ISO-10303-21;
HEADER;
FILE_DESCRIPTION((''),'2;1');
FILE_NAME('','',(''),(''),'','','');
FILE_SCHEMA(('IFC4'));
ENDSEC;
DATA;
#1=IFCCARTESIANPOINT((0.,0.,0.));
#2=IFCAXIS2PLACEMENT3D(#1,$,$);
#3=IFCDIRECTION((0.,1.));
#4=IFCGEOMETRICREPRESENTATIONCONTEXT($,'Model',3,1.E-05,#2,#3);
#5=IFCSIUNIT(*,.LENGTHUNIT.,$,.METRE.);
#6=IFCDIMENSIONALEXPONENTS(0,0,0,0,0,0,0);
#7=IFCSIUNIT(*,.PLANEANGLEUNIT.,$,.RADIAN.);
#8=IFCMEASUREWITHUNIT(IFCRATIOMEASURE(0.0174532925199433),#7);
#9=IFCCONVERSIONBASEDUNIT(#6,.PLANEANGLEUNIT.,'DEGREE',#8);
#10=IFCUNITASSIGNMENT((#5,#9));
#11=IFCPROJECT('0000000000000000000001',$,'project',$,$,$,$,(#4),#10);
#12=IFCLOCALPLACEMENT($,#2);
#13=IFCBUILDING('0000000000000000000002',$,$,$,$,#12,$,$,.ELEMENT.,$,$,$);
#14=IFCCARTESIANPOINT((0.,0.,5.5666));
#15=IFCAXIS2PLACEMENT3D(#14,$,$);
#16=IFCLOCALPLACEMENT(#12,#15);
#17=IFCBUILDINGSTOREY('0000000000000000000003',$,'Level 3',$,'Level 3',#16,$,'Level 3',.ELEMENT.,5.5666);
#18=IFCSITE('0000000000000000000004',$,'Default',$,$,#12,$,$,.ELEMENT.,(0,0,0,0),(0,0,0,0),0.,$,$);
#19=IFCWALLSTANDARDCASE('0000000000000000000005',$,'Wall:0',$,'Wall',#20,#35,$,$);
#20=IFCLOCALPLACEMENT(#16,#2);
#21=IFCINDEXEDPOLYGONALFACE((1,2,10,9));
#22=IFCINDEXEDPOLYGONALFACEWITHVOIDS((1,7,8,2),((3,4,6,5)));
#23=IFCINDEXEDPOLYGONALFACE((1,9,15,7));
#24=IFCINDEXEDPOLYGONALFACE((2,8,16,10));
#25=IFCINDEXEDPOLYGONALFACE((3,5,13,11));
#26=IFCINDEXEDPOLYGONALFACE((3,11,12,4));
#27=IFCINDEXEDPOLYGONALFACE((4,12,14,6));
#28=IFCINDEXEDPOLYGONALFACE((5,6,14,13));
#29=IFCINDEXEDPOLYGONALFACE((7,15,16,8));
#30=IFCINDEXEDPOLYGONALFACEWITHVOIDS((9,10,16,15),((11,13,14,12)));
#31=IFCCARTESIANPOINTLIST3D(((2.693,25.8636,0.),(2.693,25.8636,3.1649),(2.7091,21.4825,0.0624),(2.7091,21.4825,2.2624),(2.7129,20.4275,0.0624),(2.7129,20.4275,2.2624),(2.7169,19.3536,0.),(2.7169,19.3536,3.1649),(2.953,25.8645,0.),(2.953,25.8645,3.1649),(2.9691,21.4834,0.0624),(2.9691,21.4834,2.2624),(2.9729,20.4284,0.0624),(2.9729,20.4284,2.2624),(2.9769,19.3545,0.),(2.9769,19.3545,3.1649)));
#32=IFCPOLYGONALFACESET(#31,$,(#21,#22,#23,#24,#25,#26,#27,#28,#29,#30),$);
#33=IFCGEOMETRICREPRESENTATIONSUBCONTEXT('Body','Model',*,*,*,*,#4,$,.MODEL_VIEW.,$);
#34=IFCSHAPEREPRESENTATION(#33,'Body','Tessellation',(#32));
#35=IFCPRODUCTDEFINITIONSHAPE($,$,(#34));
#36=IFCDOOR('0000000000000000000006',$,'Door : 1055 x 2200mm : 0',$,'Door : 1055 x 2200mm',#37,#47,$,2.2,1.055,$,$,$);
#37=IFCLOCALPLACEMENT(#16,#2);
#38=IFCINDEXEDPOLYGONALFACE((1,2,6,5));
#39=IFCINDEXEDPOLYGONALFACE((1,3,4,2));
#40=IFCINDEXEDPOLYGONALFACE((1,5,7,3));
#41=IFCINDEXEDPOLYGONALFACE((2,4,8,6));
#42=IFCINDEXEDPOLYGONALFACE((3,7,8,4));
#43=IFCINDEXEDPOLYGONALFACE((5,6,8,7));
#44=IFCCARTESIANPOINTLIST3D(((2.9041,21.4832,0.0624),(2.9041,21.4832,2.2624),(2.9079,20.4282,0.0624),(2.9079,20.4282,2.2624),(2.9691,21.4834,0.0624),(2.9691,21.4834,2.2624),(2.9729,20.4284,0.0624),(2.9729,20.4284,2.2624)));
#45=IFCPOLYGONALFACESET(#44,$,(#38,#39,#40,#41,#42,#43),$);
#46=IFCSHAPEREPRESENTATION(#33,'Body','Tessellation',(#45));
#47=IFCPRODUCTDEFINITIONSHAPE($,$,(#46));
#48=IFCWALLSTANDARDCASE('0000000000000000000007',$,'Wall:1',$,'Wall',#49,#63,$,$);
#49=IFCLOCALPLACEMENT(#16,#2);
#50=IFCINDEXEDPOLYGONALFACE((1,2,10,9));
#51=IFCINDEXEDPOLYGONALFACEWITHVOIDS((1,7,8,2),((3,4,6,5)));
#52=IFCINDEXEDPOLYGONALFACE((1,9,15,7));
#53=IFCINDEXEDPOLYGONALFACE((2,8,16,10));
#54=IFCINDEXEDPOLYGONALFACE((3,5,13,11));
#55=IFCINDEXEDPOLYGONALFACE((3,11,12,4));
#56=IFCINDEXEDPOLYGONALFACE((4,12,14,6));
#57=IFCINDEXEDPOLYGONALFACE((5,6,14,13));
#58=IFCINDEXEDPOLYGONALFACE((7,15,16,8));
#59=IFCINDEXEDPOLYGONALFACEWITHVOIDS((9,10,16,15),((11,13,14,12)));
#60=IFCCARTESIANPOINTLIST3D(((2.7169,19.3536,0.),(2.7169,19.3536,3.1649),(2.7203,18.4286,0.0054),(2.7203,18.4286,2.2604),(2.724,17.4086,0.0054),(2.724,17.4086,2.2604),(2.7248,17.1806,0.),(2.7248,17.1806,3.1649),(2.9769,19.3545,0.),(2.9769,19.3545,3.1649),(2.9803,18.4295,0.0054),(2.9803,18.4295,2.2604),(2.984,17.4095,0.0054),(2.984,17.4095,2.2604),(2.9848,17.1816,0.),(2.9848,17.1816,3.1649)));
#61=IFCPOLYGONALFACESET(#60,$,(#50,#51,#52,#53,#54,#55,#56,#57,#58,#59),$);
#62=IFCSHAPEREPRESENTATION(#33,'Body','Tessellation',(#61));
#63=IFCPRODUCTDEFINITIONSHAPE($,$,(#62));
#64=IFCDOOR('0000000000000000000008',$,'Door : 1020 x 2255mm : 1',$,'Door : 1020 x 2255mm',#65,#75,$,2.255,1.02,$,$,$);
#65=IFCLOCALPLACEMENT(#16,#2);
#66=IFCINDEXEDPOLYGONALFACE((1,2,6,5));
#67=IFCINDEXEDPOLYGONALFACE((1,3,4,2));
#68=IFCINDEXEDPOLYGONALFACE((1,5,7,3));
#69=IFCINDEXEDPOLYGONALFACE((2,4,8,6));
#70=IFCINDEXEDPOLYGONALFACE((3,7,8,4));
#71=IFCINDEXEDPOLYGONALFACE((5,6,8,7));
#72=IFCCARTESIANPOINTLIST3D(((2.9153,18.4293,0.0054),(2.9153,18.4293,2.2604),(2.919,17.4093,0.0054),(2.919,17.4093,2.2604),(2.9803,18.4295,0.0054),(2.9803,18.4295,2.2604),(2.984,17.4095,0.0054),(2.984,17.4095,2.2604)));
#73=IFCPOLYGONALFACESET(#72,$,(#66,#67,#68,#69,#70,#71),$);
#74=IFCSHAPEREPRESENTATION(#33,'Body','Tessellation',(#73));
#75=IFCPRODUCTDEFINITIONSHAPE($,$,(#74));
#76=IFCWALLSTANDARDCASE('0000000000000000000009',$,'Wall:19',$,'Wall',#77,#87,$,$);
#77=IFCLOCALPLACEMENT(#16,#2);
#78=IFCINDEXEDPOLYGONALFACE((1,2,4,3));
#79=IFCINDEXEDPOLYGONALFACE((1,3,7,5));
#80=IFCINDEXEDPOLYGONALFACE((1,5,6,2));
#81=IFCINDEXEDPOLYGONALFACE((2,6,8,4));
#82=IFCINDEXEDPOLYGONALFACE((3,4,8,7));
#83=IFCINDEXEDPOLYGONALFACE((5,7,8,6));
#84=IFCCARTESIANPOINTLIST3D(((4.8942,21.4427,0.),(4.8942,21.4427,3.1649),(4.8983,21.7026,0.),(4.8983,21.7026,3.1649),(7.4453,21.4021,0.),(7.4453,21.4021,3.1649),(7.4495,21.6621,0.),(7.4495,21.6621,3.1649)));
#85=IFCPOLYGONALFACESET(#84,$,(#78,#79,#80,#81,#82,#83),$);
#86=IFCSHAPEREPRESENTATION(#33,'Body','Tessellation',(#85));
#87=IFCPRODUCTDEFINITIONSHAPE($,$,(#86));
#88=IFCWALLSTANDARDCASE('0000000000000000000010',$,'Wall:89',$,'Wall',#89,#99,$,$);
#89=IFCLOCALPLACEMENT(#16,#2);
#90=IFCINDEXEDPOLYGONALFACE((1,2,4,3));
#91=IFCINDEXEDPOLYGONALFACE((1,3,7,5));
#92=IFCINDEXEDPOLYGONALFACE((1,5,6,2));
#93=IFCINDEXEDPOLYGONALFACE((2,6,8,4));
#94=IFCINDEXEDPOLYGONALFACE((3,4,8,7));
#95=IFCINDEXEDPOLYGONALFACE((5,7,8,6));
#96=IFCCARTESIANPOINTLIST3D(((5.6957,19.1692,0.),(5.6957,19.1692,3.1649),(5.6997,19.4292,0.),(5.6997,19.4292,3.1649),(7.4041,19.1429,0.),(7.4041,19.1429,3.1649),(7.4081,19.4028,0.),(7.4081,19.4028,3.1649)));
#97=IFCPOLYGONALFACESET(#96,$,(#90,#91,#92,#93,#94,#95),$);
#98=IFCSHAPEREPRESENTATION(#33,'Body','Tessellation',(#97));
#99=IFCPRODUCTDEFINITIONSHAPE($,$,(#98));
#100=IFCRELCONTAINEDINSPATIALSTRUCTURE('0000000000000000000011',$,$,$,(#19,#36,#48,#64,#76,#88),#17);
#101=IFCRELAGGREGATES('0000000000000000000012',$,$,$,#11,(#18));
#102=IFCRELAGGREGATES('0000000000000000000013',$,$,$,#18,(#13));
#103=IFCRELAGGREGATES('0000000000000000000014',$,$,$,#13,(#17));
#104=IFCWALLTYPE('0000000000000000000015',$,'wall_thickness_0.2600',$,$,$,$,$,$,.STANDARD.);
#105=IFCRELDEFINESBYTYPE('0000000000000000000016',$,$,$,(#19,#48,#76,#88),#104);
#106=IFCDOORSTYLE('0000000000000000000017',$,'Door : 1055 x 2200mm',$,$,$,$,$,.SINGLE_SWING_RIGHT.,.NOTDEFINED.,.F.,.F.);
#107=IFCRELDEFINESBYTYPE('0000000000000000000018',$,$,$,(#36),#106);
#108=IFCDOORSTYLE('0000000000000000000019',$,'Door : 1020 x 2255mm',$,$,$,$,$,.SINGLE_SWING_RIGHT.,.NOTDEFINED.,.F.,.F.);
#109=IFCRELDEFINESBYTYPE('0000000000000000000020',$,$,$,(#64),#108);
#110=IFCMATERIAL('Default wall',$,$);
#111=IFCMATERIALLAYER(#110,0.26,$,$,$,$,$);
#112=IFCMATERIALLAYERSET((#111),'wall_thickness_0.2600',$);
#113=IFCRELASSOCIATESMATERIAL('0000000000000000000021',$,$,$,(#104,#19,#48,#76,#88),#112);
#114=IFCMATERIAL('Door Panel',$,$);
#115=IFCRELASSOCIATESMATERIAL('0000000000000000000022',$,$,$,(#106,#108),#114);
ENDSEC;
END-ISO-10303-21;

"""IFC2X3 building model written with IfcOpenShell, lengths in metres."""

from ifc_helpers import new_model, entity, si_unit, converted_unit, direction, frame, frame_2d, origin, origin_2d_with_axis, place, context, subcontext, project, spatial, polyline, rectangle, outline, extrude, source, transform, mapped, material, layer, layer_set, layer_usage, type_object, type_shapes, element, fill, save


model = new_model("IFC2X3")

# Units and contexts
model_context = context("Model", 3, precision=1e-05, world=origin(), true_north=direction((0.0, 1.0)))
body_context = subcontext(model_context, "Body", "Model", "MODEL_VIEW")
ifc_project = project(units=[si_unit("LENGTHUNIT", "METRE"), converted_unit("PLANEANGLEUNIT", "DEGREE", entity("IfcRatioMeasure", 0.0174532925199433), si_unit("PLANEANGLEUNIT", "RADIAN"), dimensions=[0, 0, 0, 0, 0, 0, 0])], contexts=[model_context])

# Site, building, storey
placement_1 = place(None, origin())
site = spatial("IfcSite", under=ifc_project, at=placement_1, Name="Default", CompositionType="ELEMENT", RefLatitude=(0, 0, 0, 0), RefLongitude=(0, 0, 0, 0), RefElevation=0.0)
building = spatial("IfcBuilding", under=site, at=placement_1, CompositionType="ELEMENT")
storey_placement = place(placement_1, frame((0.0, 0.0, 5.5666)))
storey = spatial("IfcBuildingStorey", under=building, at=storey_placement, Name="Level 3", ObjectType="Level 3", LongName="Level 3", CompositionType="ELEMENT", Elevation=5.5666)

# Walls, openings, doors
ifc_material_1 = material(Name="Default wall")
ifc_layer_1 = layer(ifc_material_1, 0.26)
ifc_layer_set_1 = layer_set([ifc_layer_1], Name="wall_thickness_0.2600")
ifc_layer_usage_1 = layer_usage(ifc_layer_set_1, "AXIS2", "POSITIVE", -0.13)
wall_type_1 = type_object("IfcWallType", Name="wall_thickness_0.2600", PredefinedType="STANDARD", material=ifc_layer_set_1)
wall_1_placement = place(storey_placement, frame((2.823, 25.8641, 0.0), z_axis=(0.0, 0.0, 1.0), x_axis=(0.003663, -0.999993, 0.0)))
wall_1 = element("IfcWallStandardCase", 1, at=wall_1_placement, inside=storey, type_object=wall_type_1, material=ifc_layer_usage_1, Name="Wall:0", ObjectType="Wall", context=body_context, shape_type="SweptSolid", body=[
    extrude(outline(polyline([(6.5101, -0.13), (6.5101, 0.13), (0.0, 0.13), (0.0, -0.13), (6.5101, -0.13)])), origin(), (0.0, 0.0, 1.0), 3.1649),
])
opening_1_placement = place(wall_1_placement, frame((4.3811, -0.13, 0.0624)))
opening_1 = element("IfcOpeningElement", 2, at=opening_1_placement, cuts=wall_1, ObjectType="Opening", context=body_context, shape_type="SweptSolid", body=[
    extrude(rectangle(XDim=1.055, YDim=2.2, at=frame_2d((1.1, 0.5275), x_axis=(0.0, 1.0))), frame((0.0, 0.0, 0.0), z_axis=(0.0, 1.0, 0.0), x_axis=(0.0, 0.0, 1.0)), (0.0, 0.0, 1.0), 0.26),
])
ifc_material_2 = material(Name="Door Panel")
door_style_1 = type_object("IfcDoorStyle", Name="Door : 1055 x 2200mm", ConstructionType="NOTDEFINED", OperationType="SINGLE_SWING_RIGHT", ParameterTakesPrecedence=False, Sizeable=False, material=ifc_material_2)
shared_shape_1 = source(origin(), body_context, "Body", "SweptSolid", [
    extrude(rectangle(XDim=0.065, YDim=1.055, at=origin_2d_with_axis()), frame((0.5275, 0.2275, 0.0), z_axis=(0.0, 0.0, 1.0), x_axis=(0.0, 1.0, 0.0)), (0.0, 0.0, 1.0), 2.2),
])
type_shapes(door_style_1, [shared_shape_1])
door_1_placement = place(opening_1_placement, origin())
door_1 = element("IfcDoor", 3, at=door_1_placement, inside=storey, type_object=door_style_1, Name="Door : 1055 x 2200mm : 0", ObjectType="Door : 1055 x 2200mm", OverallHeight=2.2, OverallWidth=1.055, context=body_context, shape_type="MappedRepresentation", body=[
    mapped(shared_shape_1, transform((0.0, 0.0, 0.0), scale=1.0)),
])
fill(opening_1, door_1)
wall_2_placement = place(storey_placement, frame((2.8469, 19.354, 0.0), z_axis=(0.0, 0.0, 1.0), x_axis=(0.003663, -0.999993, 0.0)))
wall_2 = element("IfcWallStandardCase", 4, at=wall_2_placement, inside=storey, type_object=wall_type_1, material=ifc_layer_usage_1, Name="Wall:1", ObjectType="Wall", context=body_context, shape_type="SweptSolid", body=[
    extrude(outline(polyline([(2.173, -0.13), (2.173, 0.13), (0.0, 0.13), (0.0, -0.13), (2.173, -0.13)])), origin(), (0.0, 0.0, 1.0), 3.1649),
])
opening_2_placement = place(wall_2_placement, frame((0.925, -0.13, 0.0054)))
opening_2 = element("IfcOpeningElement", 5, at=opening_2_placement, cuts=wall_2, ObjectType="Opening", context=body_context, shape_type="SweptSolid", body=[
    extrude(rectangle(XDim=1.02, YDim=2.255, at=frame_2d((1.1275, 0.51), x_axis=(0.0, 1.0))), frame((0.0, 0.0, 0.0), z_axis=(0.0, 1.0, 0.0), x_axis=(0.0, 0.0, 1.0)), (0.0, 0.0, 1.0), 0.26),
])
door_style_2 = type_object("IfcDoorStyle", Name="Door : 1020 x 2255mm", ConstructionType="NOTDEFINED", OperationType="SINGLE_SWING_RIGHT", ParameterTakesPrecedence=False, Sizeable=False, material=ifc_material_2)
shared_shape_2 = source(origin(), body_context, "Body", "SweptSolid", [
    extrude(rectangle(XDim=0.065, YDim=1.02, at=origin_2d_with_axis()), frame((0.51, 0.2275, 0.0), z_axis=(0.0, 0.0, 1.0), x_axis=(0.0, 1.0, 0.0)), (0.0, 0.0, 1.0), 2.255),
])
type_shapes(door_style_2, [shared_shape_2])
door_2_placement = place(opening_2_placement, origin())
door_2 = element("IfcDoor", 6, at=door_2_placement, inside=storey, type_object=door_style_2, Name="Door : 1020 x 2255mm : 1", ObjectType="Door : 1020 x 2255mm", OverallHeight=2.255, OverallWidth=1.02, context=body_context, shape_type="MappedRepresentation", body=[
    mapped(shared_shape_2, transform((0.0, 0.0, 0.0), scale=1.0)),
])
fill(opening_2, door_2)

# Walls
wall_3_placement = place(storey_placement, frame((4.8963, 21.5727, 0.0), z_axis=(0.0, 0.0, 1.0), x_axis=(0.999874, -0.015899, 0.0)))
element("IfcWallStandardCase", 7, at=wall_3_placement, inside=storey, type_object=wall_type_1, material=ifc_layer_usage_1, Name="Wall:19", ObjectType="Wall", context=body_context, shape_type="SweptSolid", body=[
    extrude(outline(polyline([(2.5514, -0.13), (2.5514, 0.13), (0.0, 0.13), (0.0, -0.13), (2.5514, -0.13)])), origin(), (0.0, 0.0, 1.0), 3.1649),
])
wall_4_placement = place(storey_placement, frame((5.6977, 19.2992, 0.0), z_axis=(0.0, 0.0, 1.0), x_axis=(0.999881, -0.015434, 0.0)))
element("IfcWallStandardCase", 8, at=wall_4_placement, inside=storey, type_object=wall_type_1, material=ifc_layer_usage_1, Name="Wall:89", ObjectType="Wall", context=body_context, shape_type="SweptSolid", body=[
    extrude(outline(polyline([(1.7086, -0.13), (1.7086, 0.13), (0.0, 0.13), (0.0, -0.13), (1.7086, -0.13)])), origin(), (0.0, 0.0, 1.0), 3.1649),
])

save(model, "model.ifc")
